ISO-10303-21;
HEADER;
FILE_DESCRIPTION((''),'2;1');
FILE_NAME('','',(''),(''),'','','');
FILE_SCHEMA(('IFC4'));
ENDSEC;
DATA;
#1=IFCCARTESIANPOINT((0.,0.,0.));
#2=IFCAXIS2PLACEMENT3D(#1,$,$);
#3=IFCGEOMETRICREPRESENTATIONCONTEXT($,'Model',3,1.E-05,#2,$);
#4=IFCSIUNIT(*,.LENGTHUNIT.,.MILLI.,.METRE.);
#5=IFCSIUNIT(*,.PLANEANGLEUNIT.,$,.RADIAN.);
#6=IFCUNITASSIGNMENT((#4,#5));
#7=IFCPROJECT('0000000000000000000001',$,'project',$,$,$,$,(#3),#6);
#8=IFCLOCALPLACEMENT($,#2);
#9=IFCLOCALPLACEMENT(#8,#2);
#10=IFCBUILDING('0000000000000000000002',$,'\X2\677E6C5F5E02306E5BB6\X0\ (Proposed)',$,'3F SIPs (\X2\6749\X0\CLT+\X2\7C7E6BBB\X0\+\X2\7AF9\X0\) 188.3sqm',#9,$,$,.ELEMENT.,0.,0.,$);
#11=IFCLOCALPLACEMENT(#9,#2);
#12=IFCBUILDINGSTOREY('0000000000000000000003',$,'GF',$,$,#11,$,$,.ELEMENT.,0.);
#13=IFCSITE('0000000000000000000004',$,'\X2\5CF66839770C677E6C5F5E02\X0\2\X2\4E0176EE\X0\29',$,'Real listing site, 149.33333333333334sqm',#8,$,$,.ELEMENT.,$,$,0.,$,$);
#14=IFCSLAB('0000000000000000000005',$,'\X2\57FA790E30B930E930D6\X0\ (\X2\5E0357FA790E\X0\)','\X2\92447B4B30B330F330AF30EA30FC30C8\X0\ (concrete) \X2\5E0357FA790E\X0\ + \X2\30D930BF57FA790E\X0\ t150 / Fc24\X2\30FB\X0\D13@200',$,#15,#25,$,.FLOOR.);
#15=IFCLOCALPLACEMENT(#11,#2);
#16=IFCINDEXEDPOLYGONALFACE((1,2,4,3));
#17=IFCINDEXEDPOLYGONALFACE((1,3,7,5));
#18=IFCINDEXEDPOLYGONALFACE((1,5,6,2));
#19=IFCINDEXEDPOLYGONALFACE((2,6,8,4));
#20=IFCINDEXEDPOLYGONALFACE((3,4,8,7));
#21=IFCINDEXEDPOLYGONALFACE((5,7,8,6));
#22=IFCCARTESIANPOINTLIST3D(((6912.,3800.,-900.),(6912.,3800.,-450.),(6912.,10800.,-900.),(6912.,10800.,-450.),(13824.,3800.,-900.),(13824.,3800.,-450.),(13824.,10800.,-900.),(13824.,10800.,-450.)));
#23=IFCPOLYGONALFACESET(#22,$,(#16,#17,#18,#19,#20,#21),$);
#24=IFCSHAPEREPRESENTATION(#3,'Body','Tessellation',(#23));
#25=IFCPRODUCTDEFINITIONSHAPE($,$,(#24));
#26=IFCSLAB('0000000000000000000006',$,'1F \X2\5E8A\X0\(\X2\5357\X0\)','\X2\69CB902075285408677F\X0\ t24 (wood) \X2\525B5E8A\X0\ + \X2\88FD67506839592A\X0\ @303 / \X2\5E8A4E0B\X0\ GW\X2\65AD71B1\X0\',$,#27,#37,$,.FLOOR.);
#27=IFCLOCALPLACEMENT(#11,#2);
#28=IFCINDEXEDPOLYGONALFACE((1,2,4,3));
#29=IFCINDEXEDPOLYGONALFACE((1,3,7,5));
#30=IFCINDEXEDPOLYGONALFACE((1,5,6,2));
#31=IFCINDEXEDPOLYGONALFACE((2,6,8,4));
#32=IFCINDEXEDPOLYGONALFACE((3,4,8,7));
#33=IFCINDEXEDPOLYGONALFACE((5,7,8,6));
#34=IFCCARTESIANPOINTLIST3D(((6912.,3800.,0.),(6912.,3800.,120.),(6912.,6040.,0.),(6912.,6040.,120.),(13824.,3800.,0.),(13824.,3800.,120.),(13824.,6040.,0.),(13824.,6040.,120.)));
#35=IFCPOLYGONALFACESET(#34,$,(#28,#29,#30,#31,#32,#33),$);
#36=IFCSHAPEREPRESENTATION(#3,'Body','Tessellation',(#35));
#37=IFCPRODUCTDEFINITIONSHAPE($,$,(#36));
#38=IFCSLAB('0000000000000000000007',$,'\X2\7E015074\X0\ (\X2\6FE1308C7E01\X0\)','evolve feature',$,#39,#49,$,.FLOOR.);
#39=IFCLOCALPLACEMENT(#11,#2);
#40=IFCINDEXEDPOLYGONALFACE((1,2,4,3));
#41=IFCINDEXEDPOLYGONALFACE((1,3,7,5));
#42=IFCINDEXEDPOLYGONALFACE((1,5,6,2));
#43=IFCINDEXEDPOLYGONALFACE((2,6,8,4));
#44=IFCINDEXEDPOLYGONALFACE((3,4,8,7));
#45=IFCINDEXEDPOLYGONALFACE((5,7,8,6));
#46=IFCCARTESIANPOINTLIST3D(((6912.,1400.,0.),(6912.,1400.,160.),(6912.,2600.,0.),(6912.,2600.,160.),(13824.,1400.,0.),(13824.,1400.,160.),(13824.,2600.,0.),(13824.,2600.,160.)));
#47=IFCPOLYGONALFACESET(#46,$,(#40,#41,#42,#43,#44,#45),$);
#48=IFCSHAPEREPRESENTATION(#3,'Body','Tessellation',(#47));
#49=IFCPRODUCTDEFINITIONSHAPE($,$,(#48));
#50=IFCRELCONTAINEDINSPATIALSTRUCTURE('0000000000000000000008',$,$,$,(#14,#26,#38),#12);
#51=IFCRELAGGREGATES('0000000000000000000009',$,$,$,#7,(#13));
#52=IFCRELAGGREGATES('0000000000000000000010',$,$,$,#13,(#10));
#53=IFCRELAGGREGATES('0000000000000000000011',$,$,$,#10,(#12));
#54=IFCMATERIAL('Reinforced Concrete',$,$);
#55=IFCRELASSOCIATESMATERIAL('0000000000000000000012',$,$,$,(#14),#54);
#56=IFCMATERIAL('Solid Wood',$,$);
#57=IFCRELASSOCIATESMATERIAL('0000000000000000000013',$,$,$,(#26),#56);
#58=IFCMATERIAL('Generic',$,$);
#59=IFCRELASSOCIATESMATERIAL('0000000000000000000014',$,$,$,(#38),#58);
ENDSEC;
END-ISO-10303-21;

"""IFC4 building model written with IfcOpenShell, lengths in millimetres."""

from ifc_helpers import new_model, si_unit, frame, frame_2d, origin, place, context, project, spatial, rectangle, extrude, material, element, save


model = new_model("IFC4")

# Units and contexts
model_context = context("Model", 3, precision=1e-05, world=origin())
ifc_project = project(units=[si_unit("LENGTHUNIT", "METRE", prefix="MILLI"), si_unit("PLANEANGLEUNIT", "RADIAN")], contexts=[model_context])

# Site, building, storey
site_placement = place(None, origin())
site = spatial("IfcSite", under=ifc_project, at=site_placement, Name="島根県松江市2丁目29", ObjectType="Real listing site, 149.33333333333334sqm", CompositionType="ELEMENT", RefElevation=0.0)
building_placement = place(site_placement, origin())
building = spatial("IfcBuilding", under=site, at=building_placement, Name="松江市の家 (Proposed)", ObjectType="3F SIPs (杉CLT+籾殻+竹) 188.3sqm", CompositionType="ELEMENT", ElevationOfRefHeight=0.0, ElevationOfTerrain=0.0)
storey_placement = place(building_placement, origin())
storey = spatial("IfcBuildingStorey", under=building, at=storey_placement, Name="GF", CompositionType="ELEMENT", Elevation=0.0)

# Slabs
ifc_material_1 = material(Name="Reinforced Concrete")
slab_1_placement = place(storey_placement, frame((3456.0, 1900.0, -450.0)))
element("IfcSlab", 1, at=slab_1_placement, inside=storey, material=ifc_material_1, Name="基礎スラブ (布基礎)", Description="鉄筋コンクリート (concrete) 布基礎 + ベタ基礎 t150 / Fc24・D13@200", PredefinedType="FLOOR", context=model_context, shape_type="SweptSolid", body=[
    extrude(rectangle(XDim=6912.0, YDim=7000.0, at=frame_2d((3456.0, 3500.0))), frame((3456.0, 1900.0, -450.0)), (0.0, 0.0, 1.0), 450.0),
])
ifc_material_2 = material(Name="Solid Wood")
slab_2_placement = place(storey_placement, frame((3456.0, 1900.0, 0.0)))
element("IfcSlab", 2, at=slab_2_placement, inside=storey, material=ifc_material_2, Name="1F 床(南)", Description="構造用合板 t24 (wood) 剛床 + 製材根太 @303 / 床下 GW断熱", PredefinedType="FLOOR", context=model_context, shape_type="SweptSolid", body=[
    extrude(rectangle(XDim=6912.0, YDim=2240.0, at=frame_2d((3456.0, 1120.0))), frame((3456.0, 1900.0, 0.0)), (0.0, 0.0, 1.0), 120.0),
])
ifc_material_3 = material(Name="Generic")
slab_3_placement = place(storey_placement, frame((3456.0, 700.0, 0.0)))
element("IfcSlab", 3, at=slab_3_placement, inside=storey, material=ifc_material_3, Name="縁側 (濡れ縁)", Description="evolve feature", PredefinedType="FLOOR", context=model_context, shape_type="SweptSolid", body=[
    extrude(rectangle(XDim=6912.0, YDim=1200.0, at=frame_2d((3456.0, 600.0))), frame((3456.0, 700.0, 0.0)), (0.0, 0.0, 1.0), 160.0),
])

save(model, "model.ifc")
